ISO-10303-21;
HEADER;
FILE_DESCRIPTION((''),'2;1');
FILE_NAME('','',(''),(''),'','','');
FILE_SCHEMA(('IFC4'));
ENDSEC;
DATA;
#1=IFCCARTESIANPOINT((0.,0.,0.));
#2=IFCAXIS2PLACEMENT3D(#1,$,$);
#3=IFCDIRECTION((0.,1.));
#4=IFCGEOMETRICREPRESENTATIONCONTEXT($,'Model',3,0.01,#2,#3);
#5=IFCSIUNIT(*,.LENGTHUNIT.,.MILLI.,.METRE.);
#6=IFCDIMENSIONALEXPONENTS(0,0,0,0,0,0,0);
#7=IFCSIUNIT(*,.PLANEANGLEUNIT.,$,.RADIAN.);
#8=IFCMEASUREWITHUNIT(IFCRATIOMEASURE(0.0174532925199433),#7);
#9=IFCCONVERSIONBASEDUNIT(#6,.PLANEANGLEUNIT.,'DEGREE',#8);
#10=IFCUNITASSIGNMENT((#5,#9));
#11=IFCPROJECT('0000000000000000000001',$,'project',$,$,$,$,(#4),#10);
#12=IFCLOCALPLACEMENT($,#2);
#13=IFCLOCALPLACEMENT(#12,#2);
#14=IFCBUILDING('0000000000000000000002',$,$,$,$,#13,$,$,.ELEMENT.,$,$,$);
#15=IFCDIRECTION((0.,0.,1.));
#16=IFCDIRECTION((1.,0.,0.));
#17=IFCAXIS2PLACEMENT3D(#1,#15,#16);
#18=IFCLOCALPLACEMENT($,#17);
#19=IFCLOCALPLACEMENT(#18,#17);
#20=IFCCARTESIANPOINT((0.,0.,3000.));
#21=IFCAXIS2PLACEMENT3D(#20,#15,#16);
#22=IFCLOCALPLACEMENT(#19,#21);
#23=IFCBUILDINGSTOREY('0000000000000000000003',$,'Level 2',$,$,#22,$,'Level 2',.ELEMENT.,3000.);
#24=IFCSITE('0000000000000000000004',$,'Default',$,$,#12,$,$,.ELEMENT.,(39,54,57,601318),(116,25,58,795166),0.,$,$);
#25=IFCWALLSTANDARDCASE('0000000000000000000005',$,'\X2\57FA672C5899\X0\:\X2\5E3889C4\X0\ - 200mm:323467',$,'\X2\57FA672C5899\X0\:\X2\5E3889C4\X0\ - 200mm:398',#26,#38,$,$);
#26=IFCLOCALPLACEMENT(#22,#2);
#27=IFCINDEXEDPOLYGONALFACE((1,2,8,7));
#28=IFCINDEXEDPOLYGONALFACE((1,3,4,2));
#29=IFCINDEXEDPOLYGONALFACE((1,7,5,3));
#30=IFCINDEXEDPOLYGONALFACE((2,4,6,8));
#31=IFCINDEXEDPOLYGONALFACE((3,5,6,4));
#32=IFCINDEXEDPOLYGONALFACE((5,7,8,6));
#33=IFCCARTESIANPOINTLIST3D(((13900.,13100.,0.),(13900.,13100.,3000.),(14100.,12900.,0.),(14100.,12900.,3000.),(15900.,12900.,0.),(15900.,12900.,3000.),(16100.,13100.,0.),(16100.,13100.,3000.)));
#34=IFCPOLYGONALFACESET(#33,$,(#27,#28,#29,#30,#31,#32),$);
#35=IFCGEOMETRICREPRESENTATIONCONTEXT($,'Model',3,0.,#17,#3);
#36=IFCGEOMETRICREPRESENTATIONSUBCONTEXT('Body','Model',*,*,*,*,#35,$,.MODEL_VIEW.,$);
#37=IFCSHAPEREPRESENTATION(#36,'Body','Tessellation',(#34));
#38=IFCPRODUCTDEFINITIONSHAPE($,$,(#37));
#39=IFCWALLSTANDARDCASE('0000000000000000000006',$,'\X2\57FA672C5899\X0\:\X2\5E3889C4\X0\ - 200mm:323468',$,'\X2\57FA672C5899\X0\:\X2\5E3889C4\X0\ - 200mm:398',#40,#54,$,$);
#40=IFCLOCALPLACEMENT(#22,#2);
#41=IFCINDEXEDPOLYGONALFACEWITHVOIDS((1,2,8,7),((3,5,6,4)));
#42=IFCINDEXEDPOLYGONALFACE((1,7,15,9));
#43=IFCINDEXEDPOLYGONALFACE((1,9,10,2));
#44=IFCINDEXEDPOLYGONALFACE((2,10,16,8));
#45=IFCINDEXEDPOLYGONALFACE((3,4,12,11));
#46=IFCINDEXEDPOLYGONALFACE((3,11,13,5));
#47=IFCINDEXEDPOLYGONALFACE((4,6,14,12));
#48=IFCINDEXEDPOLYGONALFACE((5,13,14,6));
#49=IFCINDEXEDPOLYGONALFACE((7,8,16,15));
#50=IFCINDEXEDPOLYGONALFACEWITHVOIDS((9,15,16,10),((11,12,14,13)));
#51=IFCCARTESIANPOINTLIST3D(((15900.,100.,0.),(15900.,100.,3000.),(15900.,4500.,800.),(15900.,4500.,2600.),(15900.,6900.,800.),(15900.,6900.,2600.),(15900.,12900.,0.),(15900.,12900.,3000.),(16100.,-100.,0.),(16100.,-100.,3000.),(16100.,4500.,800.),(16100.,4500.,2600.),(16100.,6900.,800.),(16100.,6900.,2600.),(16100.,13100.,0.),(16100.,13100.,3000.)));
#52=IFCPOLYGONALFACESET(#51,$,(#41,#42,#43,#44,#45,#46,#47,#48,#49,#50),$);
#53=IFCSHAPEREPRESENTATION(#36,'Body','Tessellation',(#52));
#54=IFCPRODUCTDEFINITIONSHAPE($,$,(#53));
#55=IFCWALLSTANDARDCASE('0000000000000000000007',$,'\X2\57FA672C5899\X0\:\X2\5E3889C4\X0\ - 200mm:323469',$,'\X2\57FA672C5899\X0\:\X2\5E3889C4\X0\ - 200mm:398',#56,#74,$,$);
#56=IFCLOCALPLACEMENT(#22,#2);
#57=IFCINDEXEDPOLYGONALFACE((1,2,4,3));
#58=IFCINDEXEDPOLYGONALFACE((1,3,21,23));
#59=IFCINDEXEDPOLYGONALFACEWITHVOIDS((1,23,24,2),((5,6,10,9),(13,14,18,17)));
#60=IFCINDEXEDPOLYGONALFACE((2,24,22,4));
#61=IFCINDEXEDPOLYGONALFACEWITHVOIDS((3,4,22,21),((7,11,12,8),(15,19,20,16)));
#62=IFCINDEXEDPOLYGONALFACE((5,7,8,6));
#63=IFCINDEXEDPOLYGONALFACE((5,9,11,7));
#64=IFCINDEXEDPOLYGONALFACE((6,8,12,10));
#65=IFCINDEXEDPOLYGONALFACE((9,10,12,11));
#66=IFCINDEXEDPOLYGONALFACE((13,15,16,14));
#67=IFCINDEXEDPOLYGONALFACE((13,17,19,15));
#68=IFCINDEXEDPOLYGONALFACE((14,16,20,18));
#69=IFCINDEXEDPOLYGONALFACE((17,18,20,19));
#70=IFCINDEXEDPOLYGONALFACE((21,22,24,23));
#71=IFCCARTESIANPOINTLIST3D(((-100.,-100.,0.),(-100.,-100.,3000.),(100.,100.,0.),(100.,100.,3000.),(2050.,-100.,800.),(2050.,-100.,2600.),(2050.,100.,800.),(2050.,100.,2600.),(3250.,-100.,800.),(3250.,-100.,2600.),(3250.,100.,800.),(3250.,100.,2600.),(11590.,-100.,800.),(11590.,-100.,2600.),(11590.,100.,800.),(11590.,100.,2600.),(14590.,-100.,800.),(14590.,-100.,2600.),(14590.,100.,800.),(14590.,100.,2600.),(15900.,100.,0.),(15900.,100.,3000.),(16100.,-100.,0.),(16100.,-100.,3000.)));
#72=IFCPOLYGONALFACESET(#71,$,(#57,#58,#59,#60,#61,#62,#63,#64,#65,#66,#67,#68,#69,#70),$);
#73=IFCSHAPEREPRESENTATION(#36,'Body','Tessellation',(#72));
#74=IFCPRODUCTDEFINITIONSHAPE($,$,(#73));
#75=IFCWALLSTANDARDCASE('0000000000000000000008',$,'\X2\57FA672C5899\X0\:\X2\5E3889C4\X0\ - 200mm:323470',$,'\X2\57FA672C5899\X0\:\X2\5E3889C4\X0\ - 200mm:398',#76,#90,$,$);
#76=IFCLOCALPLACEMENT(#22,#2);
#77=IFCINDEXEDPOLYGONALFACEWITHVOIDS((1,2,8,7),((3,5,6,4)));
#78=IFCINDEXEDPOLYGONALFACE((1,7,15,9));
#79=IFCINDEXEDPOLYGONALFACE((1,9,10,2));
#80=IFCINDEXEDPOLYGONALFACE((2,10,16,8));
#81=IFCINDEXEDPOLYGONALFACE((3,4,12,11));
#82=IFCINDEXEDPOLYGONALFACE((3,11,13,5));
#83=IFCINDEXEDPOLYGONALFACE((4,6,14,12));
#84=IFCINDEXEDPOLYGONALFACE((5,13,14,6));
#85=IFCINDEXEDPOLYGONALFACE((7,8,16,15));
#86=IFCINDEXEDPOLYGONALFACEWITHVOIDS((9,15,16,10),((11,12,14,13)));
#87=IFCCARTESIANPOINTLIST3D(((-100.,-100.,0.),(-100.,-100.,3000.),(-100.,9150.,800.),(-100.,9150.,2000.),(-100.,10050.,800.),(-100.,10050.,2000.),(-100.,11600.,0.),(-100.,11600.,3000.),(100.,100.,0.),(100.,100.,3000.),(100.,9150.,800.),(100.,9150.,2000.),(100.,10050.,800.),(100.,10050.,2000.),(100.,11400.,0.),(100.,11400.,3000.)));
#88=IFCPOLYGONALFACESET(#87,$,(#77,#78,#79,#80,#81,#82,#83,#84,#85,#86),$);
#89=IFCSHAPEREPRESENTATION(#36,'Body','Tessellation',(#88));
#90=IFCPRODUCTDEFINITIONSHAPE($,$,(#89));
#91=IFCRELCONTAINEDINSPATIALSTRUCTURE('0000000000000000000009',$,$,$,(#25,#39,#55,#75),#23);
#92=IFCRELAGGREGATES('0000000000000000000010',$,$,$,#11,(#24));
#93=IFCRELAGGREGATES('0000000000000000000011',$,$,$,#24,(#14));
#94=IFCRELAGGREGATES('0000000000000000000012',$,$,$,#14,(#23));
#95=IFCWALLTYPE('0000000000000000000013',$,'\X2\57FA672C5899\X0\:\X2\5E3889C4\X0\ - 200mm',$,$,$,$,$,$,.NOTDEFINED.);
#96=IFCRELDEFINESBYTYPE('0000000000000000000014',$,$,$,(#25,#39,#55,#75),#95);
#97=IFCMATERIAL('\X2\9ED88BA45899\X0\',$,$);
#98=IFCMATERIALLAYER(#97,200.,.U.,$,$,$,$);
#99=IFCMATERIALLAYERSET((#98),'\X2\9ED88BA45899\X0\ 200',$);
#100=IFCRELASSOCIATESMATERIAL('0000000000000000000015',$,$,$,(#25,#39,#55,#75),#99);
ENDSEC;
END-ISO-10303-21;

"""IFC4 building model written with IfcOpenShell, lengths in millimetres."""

from ifc_helpers import new_model, entity, si_unit, converted_unit, direction, frame, origin, origin_with_axes, place, context, subcontext, project, spatial, polyline, outline, extrude, material, layer, layer_set, layer_usage, type_object, element, save


model = new_model("IFC4")

# Units and contexts
model_context_1 = context("Model", 3, precision=0.01, world=origin(), true_north=direction((0.0, 1.0)))
model_context_2 = context("Model", 3, precision=0.0, world=origin_with_axes(), true_north=direction((0.0, 1.0)))
body_context = subcontext(model_context_2, "Body", "Model", "MODEL_VIEW")
ifc_project = project(units=[si_unit("LENGTHUNIT", "METRE", prefix="MILLI"), converted_unit("PLANEANGLEUNIT", "DEGREE", entity("IfcRatioMeasure", 0.0174532925199433), si_unit("PLANEANGLEUNIT", "RADIAN"), dimensions=[0, 0, 0, 0, 0, 0, 0])], contexts=[model_context_1])

# Site, building, storey
site_placement = place(None, origin())
site = spatial("IfcSite", under=ifc_project, at=site_placement, Name="Default", CompositionType="ELEMENT", RefLatitude=(39, 54, 57, 601318), RefLongitude=(116, 25, 58, 795166), RefElevation=0.0)
building_placement = place(site_placement, origin())
building = spatial("IfcBuilding", under=site, at=building_placement, CompositionType="ELEMENT")
placement_1 = place(None, origin_with_axes())
placement_2 = place(placement_1, origin_with_axes())
storey_placement = place(placement_2, frame((0.0, 0.0, 3000.0), z_axis=(0.0, 0.0, 1.0), x_axis=(1.0, 0.0, 0.0)))
storey = spatial("IfcBuildingStorey", under=building, at=storey_placement, Name="Level 2", LongName="Level 2", CompositionType="ELEMENT", Elevation=3000.0)

# Shared definitions
ifc_material_1 = material(Name="默认墙")
ifc_layer_1 = layer(ifc_material_1, 200.0, ventilated="UNKNOWN")
ifc_layer_set_1 = layer_set([ifc_layer_1], Name="默认墙 200")
wall_type = type_object("IfcWallType", Name="基本墙:常规 - 200mm", PredefinedType="NOTDEFINED")

# Wall
ifc_layer_usage_1 = layer_usage(ifc_layer_set_1, "AXIS2", "POSITIVE", -100.0)
wall_1_placement = place(storey_placement, frame((14000.0, 13000.0, 0.0), z_axis=(0.0, 0.0, 1.0), x_axis=(1.0, 0.0, 0.0)))
element("IfcWallStandardCase", 1, at=wall_1_placement, inside=storey, type_object=wall_type, material=ifc_layer_usage_1, Name="基本墙:常规 - 200mm:323467", ObjectType="基本墙:常规 - 200mm:398", context=body_context, shape_type="SweptSolid", body=[
    extrude(outline(polyline([(100.0, -100.0), (1900.0, -100.0), (2100.0, 100.0), (-100.0, 100.0), (100.0, -100.0)])), origin_with_axes(), (0.0, 0.0, 1.0), 3000.0),
])

# Wall, opening
ifc_layer_usage_2 = layer_usage(ifc_layer_set_1, "AXIS2", "POSITIVE", -100.0)
wall_2_placement = place(storey_placement, frame((16000.0, 13000.0, 0.0), z_axis=(0.0, 0.0, 1.0), x_axis=(0.0, -1.0, 0.0)))
wall_2 = element("IfcWallStandardCase", 2, at=wall_2_placement, inside=storey, type_object=wall_type, material=ifc_layer_usage_2, Name="基本墙:常规 - 200mm:323468", ObjectType="基本墙:常规 - 200mm:398", context=body_context, shape_type="SweptSolid", body=[
    extrude(outline(polyline([(100.0, -100.0), (12900.0, -100.0), (13100.0, 100.0), (-100.0, 100.0), (100.0, -100.0)])), origin_with_axes(), (0.0, 0.0, 1.0), 3000.0),
])
opening_1_placement = place(wall_2_placement, frame((7300.0, 0.0, 800.0), z_axis=(0.0, 0.0, 1.0), x_axis=(1.0, 0.0, 0.0)))
element("IfcOpeningElement", 3, at=opening_1_placement, cuts=wall_2, context=body_context, shape_type="SweptSolid", body=[
    extrude(outline(polyline([(-1200.0, 0.0), (-1200.0, -1800.0), (1200.0, -1800.0), (1200.0, 0.0), (-1200.0, 0.0)])), frame((0.0, -100.0, 0.0), z_axis=(0.0, 1.0, 0.0), x_axis=(1.0, 0.0, 0.0)), (0.0, 0.0, 1.0), 200.0),
])

# Wall, openings
ifc_layer_usage_3 = layer_usage(ifc_layer_set_1, "AXIS2", "POSITIVE", -100.0)
wall_3_placement = place(storey_placement, frame((16000.0, 0.0, 0.0), z_axis=(0.0, 0.0, 1.0), x_axis=(-1.0, 0.0, 0.0)))
wall_3 = element("IfcWallStandardCase", 4, at=wall_3_placement, inside=storey, type_object=wall_type, material=ifc_layer_usage_3, Name="基本墙:常规 - 200mm:323469", ObjectType="基本墙:常规 - 200mm:398", context=body_context, shape_type="SweptSolid", body=[
    extrude(outline(polyline([(100.0, -100.0), (15900.0, -100.0), (16100.0, 100.0), (-100.0, 100.0), (100.0, -100.0)])), origin_with_axes(), (0.0, 0.0, 1.0), 3000.0),
])
opening_2_placement = place(wall_3_placement, frame((13350.0, 0.0, 800.0), z_axis=(0.0, 0.0, 1.0), x_axis=(1.0, 0.0, 0.0)))
element("IfcOpeningElement", 5, at=opening_2_placement, cuts=wall_3, context=body_context, shape_type="SweptSolid", body=[
    extrude(outline(polyline([(-600.0, 0.0), (-600.0, -1800.0), (600.0, -1800.0), (600.0, 0.0), (-600.0, 0.0)])), frame((0.0, -100.0, 0.0), z_axis=(0.0, 1.0, 0.0), x_axis=(1.0, 0.0, 0.0)), (0.0, 0.0, 1.0), 200.0),
])
opening_3_placement = place(wall_3_placement, frame((2910.0, 0.0, 800.0), z_axis=(0.0, 0.0, 1.0), x_axis=(1.0, 0.0, 0.0)))
element("IfcOpeningElement", 6, at=opening_3_placement, cuts=wall_3, context=body_context, shape_type="SweptSolid", body=[
    extrude(outline(polyline([(-1500.0, 0.0), (-1500.0, -1800.0), (1500.0, -1800.0), (1500.0, 0.0), (-1500.0, 0.0)])), frame((0.0, -100.0, 0.0), z_axis=(0.0, 1.0, 0.0), x_axis=(1.0, 0.0, 0.0)), (0.0, 0.0, 1.0), 200.0),
])

# Wall, opening
ifc_layer_usage_4 = layer_usage(ifc_layer_set_1, "AXIS2", "POSITIVE", -100.0)
wall_4_placement = place(storey_placement, frame((0.0, 0.0, 0.0), z_axis=(0.0, 0.0, 1.0), x_axis=(0.0, 1.0, 0.0)))
wall_4 = element("IfcWallStandardCase", 7, at=wall_4_placement, inside=storey, type_object=wall_type, material=ifc_layer_usage_4, Name="基本墙:常规 - 200mm:323470", ObjectType="基本墙:常规 - 200mm:398", context=body_context, shape_type="SweptSolid", body=[
    extrude(outline(polyline([(100.0, -100.0), (11400.0, -100.0), (11600.0, 100.0), (-100.0, 100.0), (100.0, -100.0)])), origin_with_axes(), (0.0, 0.0, 1.0), 3000.0),
])
opening_4_placement = place(wall_4_placement, frame((9600.0, 0.0, 800.0), z_axis=(0.0, 0.0, 1.0), x_axis=(1.0, 0.0, 0.0)))
element("IfcOpeningElement", 8, at=opening_4_placement, cuts=wall_4, context=body_context, shape_type="SweptSolid", body=[
    extrude(outline(polyline([(450.0, -1200.0), (450.0, 0.0), (-450.0, 0.0), (-450.0, -1200.0), (450.0, -1200.0)])), frame((0.0, 100.0, 0.0), z_axis=(0.0, -1.0, 0.0), x_axis=(-1.0, 0.0, 0.0)), (0.0, 0.0, 1.0), 200.0),
])

save(model, "model.ifc")
